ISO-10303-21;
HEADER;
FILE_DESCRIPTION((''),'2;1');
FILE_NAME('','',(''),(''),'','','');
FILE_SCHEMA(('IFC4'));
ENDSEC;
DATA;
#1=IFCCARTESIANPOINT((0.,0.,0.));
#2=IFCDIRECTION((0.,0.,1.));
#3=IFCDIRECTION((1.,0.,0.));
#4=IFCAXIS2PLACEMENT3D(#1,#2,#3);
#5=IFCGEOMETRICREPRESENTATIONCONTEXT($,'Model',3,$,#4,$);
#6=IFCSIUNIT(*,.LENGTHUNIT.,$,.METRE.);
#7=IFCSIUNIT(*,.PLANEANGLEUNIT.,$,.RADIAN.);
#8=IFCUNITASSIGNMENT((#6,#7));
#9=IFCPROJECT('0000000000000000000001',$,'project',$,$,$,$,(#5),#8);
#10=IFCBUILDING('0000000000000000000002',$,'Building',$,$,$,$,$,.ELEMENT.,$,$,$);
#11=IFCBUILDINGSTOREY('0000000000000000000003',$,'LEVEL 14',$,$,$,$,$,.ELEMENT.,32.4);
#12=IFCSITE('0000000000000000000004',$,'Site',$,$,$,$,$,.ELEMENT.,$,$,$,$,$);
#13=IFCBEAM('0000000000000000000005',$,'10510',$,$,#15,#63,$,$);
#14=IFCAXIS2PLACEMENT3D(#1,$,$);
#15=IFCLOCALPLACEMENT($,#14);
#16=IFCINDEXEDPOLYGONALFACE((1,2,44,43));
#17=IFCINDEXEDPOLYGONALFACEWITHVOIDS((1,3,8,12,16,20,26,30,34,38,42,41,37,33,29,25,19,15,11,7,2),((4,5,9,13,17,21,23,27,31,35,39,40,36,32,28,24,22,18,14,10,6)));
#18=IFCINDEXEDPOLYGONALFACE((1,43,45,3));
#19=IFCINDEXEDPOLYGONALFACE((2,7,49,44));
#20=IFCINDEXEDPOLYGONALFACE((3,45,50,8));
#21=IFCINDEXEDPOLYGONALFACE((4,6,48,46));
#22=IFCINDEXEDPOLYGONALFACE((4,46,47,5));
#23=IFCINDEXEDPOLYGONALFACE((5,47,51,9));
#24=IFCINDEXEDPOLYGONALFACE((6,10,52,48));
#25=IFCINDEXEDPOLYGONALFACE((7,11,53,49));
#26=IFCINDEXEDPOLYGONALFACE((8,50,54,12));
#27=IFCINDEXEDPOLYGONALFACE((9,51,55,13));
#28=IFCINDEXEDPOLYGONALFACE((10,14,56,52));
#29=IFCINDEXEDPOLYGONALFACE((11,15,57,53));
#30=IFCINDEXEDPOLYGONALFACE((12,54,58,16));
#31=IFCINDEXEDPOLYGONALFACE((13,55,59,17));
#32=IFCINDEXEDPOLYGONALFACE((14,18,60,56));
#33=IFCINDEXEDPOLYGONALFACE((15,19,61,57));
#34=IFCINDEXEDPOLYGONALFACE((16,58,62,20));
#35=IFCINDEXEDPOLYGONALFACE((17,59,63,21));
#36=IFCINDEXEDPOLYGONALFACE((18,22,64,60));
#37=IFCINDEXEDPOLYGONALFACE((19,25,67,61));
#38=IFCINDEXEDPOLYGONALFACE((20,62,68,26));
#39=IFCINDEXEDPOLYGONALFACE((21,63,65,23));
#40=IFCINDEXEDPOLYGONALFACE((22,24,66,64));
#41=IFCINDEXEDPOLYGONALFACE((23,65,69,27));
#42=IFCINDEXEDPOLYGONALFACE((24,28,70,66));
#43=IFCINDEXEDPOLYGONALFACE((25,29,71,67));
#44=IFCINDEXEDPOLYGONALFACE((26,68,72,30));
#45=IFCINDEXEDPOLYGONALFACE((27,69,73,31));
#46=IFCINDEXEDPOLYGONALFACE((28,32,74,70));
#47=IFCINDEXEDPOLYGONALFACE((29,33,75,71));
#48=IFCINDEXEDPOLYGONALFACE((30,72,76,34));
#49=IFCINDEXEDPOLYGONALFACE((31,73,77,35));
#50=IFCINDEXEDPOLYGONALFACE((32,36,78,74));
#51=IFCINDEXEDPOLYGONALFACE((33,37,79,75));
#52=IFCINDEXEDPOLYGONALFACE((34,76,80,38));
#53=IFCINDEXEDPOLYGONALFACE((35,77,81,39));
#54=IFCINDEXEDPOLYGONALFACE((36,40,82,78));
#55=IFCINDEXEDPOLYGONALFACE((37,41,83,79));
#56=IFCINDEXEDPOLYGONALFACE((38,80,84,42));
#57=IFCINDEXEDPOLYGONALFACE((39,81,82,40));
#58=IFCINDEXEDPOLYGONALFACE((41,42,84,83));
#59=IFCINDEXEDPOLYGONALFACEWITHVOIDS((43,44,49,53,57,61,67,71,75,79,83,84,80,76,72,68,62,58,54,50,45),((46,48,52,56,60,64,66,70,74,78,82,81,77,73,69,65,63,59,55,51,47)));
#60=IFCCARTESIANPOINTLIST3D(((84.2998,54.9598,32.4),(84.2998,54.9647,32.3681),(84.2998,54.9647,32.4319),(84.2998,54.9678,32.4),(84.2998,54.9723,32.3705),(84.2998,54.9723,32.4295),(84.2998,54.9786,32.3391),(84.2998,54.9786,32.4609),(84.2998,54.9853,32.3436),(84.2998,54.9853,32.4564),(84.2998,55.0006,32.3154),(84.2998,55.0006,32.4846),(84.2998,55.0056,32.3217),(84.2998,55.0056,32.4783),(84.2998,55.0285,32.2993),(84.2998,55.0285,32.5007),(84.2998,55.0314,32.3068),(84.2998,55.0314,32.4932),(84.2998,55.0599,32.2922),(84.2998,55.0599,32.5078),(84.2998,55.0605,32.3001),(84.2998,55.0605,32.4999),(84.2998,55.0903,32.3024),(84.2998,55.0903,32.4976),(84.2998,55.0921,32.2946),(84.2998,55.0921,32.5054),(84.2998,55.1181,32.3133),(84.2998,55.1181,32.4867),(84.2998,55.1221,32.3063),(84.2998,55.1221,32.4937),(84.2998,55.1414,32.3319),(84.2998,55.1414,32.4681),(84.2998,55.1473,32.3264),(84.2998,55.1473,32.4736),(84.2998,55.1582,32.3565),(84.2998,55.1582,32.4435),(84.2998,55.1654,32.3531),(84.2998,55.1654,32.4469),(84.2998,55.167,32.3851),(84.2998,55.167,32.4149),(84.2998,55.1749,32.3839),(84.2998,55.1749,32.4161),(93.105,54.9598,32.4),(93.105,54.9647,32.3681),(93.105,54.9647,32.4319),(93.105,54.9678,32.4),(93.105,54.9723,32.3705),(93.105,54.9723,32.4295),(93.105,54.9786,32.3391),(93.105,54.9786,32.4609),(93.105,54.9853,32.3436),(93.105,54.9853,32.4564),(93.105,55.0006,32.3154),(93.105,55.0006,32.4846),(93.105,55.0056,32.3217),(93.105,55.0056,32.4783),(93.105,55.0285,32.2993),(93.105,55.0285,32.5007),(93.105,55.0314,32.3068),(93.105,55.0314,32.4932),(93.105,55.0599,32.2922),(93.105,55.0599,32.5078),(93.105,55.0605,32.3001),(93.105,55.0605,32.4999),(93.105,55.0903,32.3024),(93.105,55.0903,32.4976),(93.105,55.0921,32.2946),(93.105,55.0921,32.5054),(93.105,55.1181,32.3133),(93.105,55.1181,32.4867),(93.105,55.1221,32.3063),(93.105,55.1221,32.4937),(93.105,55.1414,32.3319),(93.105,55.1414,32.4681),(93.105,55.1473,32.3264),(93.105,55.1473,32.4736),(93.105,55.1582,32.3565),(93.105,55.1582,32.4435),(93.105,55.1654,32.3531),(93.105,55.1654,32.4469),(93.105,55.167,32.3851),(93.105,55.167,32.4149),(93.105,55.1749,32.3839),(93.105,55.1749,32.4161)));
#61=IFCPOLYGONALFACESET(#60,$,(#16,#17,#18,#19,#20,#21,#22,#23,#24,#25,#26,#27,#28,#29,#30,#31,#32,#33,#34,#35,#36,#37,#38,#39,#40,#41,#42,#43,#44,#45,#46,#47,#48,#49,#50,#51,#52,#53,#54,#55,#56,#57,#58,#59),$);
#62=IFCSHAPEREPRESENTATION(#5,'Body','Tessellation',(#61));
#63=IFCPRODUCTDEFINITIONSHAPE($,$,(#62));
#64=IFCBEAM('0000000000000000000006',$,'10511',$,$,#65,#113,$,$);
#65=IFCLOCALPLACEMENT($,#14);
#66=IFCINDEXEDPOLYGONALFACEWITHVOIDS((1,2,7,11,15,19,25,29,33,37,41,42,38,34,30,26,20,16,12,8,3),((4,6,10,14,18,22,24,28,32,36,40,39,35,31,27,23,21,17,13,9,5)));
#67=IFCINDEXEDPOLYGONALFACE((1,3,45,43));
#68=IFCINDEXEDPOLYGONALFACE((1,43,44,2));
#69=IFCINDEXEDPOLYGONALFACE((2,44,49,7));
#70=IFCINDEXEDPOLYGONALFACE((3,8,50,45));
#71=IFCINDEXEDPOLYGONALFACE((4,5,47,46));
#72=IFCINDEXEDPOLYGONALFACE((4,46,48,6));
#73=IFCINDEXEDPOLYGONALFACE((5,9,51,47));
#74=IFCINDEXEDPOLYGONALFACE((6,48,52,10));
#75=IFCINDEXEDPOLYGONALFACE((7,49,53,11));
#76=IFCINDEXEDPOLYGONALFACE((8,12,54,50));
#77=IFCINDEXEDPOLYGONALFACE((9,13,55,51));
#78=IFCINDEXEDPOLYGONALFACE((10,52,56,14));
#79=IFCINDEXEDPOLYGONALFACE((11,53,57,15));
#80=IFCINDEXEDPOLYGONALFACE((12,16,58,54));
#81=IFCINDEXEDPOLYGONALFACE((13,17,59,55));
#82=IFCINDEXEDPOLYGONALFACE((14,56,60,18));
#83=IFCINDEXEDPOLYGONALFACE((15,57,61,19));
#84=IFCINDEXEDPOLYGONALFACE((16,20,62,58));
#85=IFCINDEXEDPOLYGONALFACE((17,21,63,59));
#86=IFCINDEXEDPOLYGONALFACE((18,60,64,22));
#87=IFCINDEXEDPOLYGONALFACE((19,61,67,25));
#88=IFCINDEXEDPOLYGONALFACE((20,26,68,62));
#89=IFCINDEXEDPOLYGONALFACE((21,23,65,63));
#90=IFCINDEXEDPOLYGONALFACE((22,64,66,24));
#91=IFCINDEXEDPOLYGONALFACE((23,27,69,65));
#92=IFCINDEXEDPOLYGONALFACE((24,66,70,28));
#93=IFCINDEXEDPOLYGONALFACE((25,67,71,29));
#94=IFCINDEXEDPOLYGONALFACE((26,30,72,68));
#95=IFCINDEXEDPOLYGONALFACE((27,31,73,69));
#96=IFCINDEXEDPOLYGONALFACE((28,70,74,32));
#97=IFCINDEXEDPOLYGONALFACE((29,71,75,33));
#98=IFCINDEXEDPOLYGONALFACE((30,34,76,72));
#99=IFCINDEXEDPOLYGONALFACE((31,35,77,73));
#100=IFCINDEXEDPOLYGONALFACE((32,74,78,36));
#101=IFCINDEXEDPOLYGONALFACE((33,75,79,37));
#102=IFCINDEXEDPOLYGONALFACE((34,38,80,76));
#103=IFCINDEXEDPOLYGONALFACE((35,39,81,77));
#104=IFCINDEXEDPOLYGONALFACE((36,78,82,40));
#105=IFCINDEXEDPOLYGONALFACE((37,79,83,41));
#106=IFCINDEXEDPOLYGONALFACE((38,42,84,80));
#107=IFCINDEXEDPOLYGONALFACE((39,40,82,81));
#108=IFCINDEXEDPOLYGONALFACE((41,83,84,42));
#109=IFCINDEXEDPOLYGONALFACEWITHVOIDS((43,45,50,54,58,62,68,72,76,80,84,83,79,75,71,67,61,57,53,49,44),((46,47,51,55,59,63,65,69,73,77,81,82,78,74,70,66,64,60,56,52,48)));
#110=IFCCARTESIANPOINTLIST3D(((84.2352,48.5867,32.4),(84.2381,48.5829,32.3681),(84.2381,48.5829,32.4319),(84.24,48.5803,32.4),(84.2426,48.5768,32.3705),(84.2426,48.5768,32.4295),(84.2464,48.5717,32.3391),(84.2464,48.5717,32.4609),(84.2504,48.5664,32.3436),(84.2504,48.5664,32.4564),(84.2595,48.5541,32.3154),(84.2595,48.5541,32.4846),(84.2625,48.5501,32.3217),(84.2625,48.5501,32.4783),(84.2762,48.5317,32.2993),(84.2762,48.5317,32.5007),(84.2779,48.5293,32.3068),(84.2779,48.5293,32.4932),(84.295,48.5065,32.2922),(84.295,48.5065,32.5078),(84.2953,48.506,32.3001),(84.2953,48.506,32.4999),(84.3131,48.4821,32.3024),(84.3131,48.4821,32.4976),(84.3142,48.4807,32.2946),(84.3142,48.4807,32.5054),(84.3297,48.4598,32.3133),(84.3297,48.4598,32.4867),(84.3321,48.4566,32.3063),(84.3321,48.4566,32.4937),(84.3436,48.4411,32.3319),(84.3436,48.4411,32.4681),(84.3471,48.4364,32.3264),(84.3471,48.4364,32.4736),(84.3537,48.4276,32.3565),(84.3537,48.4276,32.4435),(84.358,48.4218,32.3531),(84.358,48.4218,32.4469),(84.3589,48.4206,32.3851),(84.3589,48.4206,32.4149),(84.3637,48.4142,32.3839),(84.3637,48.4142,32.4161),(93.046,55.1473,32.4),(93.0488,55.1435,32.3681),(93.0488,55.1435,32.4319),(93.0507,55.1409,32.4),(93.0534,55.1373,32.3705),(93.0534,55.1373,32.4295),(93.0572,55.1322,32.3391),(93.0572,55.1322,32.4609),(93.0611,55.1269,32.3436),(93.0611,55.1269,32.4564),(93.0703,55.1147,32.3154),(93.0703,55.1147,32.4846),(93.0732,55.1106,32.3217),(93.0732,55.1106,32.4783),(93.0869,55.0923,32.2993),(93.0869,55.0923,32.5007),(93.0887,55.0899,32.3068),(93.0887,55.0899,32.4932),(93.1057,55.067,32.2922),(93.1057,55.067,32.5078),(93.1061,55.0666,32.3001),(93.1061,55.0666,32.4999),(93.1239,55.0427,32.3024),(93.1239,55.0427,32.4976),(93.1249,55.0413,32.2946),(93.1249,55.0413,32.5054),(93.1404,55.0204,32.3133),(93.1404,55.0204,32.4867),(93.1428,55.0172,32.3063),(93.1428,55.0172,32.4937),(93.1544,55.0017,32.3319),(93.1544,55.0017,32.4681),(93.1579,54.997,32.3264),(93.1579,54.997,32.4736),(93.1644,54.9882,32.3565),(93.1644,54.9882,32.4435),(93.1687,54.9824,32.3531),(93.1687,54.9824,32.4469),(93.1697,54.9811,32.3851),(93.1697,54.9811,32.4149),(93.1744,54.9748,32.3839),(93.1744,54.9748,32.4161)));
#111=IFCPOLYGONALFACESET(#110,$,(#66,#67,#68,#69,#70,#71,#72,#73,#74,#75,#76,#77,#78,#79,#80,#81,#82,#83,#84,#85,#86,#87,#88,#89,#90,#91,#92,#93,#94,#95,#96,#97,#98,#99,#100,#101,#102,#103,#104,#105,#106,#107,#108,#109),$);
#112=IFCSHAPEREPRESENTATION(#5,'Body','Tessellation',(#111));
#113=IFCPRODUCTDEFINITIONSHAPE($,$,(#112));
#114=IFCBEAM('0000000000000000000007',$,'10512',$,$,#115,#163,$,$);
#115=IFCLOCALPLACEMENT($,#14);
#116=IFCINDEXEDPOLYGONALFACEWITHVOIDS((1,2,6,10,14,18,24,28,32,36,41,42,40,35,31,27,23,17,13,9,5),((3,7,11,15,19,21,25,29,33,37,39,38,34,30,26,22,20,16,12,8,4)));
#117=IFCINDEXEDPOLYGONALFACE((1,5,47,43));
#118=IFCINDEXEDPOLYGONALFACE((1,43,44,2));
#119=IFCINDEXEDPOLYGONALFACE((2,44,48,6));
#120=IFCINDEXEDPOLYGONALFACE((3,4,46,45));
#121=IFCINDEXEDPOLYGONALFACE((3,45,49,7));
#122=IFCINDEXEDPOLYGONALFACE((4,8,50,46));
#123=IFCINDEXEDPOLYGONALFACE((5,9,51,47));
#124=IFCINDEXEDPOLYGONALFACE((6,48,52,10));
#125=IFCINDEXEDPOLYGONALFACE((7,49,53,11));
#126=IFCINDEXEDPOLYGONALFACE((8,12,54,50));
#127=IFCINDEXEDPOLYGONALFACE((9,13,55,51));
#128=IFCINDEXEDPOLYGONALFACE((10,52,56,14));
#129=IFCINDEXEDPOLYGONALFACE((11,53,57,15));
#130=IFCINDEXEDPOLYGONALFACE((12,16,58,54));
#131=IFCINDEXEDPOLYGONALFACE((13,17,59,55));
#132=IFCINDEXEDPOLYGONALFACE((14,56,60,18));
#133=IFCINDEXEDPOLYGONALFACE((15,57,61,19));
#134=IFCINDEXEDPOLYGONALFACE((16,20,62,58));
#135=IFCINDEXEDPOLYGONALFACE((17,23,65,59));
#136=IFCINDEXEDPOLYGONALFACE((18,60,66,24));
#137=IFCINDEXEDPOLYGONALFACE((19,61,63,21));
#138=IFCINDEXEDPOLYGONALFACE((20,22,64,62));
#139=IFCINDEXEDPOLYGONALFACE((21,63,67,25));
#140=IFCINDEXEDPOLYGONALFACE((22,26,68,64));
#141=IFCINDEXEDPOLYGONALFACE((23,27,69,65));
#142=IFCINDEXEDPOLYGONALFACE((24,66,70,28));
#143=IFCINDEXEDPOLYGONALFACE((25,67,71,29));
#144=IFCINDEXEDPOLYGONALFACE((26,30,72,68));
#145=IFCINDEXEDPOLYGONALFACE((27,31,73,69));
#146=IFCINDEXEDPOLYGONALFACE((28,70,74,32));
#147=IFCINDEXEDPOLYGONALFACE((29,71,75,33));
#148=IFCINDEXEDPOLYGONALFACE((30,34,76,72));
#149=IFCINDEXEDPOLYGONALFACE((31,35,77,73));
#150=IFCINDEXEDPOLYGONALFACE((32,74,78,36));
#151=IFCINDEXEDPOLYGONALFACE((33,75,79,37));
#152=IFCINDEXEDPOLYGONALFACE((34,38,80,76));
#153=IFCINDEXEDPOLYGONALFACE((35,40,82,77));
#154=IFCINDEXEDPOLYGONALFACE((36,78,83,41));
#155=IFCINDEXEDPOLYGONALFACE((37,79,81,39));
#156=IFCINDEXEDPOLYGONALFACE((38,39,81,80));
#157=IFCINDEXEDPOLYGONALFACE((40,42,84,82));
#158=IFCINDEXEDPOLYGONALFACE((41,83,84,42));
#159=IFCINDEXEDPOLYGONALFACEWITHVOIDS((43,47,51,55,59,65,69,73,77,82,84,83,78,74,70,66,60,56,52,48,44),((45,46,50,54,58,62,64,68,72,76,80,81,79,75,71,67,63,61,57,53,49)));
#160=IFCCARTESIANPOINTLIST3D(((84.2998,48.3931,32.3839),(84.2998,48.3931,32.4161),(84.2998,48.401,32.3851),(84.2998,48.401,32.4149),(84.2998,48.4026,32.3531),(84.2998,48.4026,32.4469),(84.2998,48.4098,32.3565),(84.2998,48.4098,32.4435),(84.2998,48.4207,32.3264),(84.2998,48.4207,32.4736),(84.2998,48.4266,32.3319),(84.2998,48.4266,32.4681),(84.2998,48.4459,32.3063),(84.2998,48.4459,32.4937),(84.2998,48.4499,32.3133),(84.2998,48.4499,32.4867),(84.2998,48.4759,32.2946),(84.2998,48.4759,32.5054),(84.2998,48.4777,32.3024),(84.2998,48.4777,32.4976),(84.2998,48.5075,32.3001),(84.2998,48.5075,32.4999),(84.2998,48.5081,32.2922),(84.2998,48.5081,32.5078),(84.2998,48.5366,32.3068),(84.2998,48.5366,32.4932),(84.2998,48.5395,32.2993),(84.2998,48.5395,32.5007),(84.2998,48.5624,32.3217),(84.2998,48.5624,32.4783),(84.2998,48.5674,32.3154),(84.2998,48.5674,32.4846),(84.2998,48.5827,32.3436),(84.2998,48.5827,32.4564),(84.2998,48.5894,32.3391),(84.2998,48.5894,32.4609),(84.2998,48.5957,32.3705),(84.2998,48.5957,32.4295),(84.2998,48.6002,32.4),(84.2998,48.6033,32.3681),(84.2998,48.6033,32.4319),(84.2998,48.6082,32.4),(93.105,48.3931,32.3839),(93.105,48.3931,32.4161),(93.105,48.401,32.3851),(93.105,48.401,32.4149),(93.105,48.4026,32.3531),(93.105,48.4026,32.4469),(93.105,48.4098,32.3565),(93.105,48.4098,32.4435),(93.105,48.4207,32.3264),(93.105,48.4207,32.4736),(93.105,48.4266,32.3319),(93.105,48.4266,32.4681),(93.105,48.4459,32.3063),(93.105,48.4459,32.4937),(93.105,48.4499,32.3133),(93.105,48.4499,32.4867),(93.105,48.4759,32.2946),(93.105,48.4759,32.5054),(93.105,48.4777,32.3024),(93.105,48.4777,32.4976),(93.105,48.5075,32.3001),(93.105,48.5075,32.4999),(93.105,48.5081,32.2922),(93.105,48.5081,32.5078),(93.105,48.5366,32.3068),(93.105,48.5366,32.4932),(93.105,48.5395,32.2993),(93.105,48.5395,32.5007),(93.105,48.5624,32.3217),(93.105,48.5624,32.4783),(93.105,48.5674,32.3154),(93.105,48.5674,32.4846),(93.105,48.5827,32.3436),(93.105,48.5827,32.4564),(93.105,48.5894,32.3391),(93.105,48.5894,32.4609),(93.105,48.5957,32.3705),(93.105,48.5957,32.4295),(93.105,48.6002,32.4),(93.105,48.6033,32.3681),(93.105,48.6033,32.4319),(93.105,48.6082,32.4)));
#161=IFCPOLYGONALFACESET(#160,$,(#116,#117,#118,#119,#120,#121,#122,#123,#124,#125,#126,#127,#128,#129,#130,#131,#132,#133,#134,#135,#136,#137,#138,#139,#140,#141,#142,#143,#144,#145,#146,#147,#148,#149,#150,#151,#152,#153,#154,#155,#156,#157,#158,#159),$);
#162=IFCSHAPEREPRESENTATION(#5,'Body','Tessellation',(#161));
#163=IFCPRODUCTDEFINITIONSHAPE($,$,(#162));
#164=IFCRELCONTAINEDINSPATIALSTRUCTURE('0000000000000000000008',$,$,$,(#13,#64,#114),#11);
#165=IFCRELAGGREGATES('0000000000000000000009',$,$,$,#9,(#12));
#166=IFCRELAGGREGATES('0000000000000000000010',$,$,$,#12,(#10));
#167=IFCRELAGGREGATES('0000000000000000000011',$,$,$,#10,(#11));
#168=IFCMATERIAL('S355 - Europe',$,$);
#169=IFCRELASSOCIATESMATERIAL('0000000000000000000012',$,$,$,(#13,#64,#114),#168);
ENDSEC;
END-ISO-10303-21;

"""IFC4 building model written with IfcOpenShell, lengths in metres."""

from ifc_helpers import new_model, si_unit, frame, origin_with_axes, origin_2d_with_axis, place, context, project, spatial, hollow_circle, extrude, material, material_profile, profile_set, profile_usage, element, save


model = new_model("IFC4")

# Units and contexts
model_context = context("Model", 3, world=origin_with_axes())
ifc_project = project(units=[si_unit("LENGTHUNIT", "METRE"), si_unit("PLANEANGLEUNIT", "RADIAN")], contexts=[model_context])

# Site, building, storey
site = spatial("IfcSite", under=ifc_project, Name="Site", CompositionType="ELEMENT")
building = spatial("IfcBuilding", under=site, Name="Building", CompositionType="ELEMENT")
storey = spatial("IfcBuildingStorey", under=building, Name="LEVEL 14", CompositionType="ELEMENT", Elevation=32.4)

# Shared definitions
ifc_material = material(Name="S355 - Europe")

# Beams
ifc_material_profile_1 = material_profile(ifc_material, hollow_circle(Radius=0.1081, WallThickness=0.008, at=origin_2d_with_axis()))
ifc_profile_set_1 = profile_set([ifc_material_profile_1])
ifc_profile_usage_1 = profile_usage(ifc_profile_set_1, cardinal=10)
beam_1_placement = place(None, frame((93.105, 55.068, 32.4), z_axis=(-1.0, 0.0, 0.0), x_axis=(0.0, -1.0, 0.0)))
element("IfcBeam", 1, at=beam_1_placement, inside=storey, material=ifc_profile_usage_1, Name="10510", context=model_context, shape_type="SweptSolid", body=[
    extrude(hollow_circle(Radius=0.1081, WallThickness=0.008, at=origin_2d_with_axis()), origin_with_axes(), (0.0, 0.0, 1.0), 8.8052),
])
ifc_material_profile_2 = material_profile(ifc_material, hollow_circle(Radius=0.1081, WallThickness=0.008, at=origin_2d_with_axis()))
ifc_profile_set_2 = profile_set([ifc_material_profile_2])
ifc_profile_usage_2 = profile_usage(ifc_profile_set_2, cardinal=10)
beam_2_placement = place(None, frame((84.2998, 48.5, 32.4), z_axis=(0.80207, 0.59723, 0.0), x_axis=(-0.597746, 0.801686, 0.0)))
element("IfcBeam", 2, at=beam_2_placement, inside=storey, material=ifc_profile_usage_2, Name="10511", context=model_context, shape_type="SweptSolid", body=[
    extrude(hollow_circle(Radius=0.1081, WallThickness=0.008, at=origin_2d_with_axis()), origin_with_axes(), (0.0, 0.0, 1.0), 10.985),
])
ifc_material_profile_3 = material_profile(ifc_material, hollow_circle(Radius=0.1081, WallThickness=0.008, at=origin_2d_with_axis()))
ifc_profile_set_3 = profile_set([ifc_material_profile_3])
ifc_profile_usage_3 = profile_usage(ifc_profile_set_3, cardinal=10)
beam_3_placement = place(None, frame((84.2998, 48.5, 32.4), z_axis=(1.0, 0.0, 0.0), x_axis=(0.0, 1.0, 0.0)))
element("IfcBeam", 3, at=beam_3_placement, inside=storey, material=ifc_profile_usage_3, Name="10512", context=model_context, shape_type="SweptSolid", body=[
    extrude(hollow_circle(Radius=0.1081, WallThickness=0.008, at=origin_2d_with_axis()), origin_with_axes(), (0.0, 0.0, 1.0), 8.8052),
])

save(model, "model.ifc")
